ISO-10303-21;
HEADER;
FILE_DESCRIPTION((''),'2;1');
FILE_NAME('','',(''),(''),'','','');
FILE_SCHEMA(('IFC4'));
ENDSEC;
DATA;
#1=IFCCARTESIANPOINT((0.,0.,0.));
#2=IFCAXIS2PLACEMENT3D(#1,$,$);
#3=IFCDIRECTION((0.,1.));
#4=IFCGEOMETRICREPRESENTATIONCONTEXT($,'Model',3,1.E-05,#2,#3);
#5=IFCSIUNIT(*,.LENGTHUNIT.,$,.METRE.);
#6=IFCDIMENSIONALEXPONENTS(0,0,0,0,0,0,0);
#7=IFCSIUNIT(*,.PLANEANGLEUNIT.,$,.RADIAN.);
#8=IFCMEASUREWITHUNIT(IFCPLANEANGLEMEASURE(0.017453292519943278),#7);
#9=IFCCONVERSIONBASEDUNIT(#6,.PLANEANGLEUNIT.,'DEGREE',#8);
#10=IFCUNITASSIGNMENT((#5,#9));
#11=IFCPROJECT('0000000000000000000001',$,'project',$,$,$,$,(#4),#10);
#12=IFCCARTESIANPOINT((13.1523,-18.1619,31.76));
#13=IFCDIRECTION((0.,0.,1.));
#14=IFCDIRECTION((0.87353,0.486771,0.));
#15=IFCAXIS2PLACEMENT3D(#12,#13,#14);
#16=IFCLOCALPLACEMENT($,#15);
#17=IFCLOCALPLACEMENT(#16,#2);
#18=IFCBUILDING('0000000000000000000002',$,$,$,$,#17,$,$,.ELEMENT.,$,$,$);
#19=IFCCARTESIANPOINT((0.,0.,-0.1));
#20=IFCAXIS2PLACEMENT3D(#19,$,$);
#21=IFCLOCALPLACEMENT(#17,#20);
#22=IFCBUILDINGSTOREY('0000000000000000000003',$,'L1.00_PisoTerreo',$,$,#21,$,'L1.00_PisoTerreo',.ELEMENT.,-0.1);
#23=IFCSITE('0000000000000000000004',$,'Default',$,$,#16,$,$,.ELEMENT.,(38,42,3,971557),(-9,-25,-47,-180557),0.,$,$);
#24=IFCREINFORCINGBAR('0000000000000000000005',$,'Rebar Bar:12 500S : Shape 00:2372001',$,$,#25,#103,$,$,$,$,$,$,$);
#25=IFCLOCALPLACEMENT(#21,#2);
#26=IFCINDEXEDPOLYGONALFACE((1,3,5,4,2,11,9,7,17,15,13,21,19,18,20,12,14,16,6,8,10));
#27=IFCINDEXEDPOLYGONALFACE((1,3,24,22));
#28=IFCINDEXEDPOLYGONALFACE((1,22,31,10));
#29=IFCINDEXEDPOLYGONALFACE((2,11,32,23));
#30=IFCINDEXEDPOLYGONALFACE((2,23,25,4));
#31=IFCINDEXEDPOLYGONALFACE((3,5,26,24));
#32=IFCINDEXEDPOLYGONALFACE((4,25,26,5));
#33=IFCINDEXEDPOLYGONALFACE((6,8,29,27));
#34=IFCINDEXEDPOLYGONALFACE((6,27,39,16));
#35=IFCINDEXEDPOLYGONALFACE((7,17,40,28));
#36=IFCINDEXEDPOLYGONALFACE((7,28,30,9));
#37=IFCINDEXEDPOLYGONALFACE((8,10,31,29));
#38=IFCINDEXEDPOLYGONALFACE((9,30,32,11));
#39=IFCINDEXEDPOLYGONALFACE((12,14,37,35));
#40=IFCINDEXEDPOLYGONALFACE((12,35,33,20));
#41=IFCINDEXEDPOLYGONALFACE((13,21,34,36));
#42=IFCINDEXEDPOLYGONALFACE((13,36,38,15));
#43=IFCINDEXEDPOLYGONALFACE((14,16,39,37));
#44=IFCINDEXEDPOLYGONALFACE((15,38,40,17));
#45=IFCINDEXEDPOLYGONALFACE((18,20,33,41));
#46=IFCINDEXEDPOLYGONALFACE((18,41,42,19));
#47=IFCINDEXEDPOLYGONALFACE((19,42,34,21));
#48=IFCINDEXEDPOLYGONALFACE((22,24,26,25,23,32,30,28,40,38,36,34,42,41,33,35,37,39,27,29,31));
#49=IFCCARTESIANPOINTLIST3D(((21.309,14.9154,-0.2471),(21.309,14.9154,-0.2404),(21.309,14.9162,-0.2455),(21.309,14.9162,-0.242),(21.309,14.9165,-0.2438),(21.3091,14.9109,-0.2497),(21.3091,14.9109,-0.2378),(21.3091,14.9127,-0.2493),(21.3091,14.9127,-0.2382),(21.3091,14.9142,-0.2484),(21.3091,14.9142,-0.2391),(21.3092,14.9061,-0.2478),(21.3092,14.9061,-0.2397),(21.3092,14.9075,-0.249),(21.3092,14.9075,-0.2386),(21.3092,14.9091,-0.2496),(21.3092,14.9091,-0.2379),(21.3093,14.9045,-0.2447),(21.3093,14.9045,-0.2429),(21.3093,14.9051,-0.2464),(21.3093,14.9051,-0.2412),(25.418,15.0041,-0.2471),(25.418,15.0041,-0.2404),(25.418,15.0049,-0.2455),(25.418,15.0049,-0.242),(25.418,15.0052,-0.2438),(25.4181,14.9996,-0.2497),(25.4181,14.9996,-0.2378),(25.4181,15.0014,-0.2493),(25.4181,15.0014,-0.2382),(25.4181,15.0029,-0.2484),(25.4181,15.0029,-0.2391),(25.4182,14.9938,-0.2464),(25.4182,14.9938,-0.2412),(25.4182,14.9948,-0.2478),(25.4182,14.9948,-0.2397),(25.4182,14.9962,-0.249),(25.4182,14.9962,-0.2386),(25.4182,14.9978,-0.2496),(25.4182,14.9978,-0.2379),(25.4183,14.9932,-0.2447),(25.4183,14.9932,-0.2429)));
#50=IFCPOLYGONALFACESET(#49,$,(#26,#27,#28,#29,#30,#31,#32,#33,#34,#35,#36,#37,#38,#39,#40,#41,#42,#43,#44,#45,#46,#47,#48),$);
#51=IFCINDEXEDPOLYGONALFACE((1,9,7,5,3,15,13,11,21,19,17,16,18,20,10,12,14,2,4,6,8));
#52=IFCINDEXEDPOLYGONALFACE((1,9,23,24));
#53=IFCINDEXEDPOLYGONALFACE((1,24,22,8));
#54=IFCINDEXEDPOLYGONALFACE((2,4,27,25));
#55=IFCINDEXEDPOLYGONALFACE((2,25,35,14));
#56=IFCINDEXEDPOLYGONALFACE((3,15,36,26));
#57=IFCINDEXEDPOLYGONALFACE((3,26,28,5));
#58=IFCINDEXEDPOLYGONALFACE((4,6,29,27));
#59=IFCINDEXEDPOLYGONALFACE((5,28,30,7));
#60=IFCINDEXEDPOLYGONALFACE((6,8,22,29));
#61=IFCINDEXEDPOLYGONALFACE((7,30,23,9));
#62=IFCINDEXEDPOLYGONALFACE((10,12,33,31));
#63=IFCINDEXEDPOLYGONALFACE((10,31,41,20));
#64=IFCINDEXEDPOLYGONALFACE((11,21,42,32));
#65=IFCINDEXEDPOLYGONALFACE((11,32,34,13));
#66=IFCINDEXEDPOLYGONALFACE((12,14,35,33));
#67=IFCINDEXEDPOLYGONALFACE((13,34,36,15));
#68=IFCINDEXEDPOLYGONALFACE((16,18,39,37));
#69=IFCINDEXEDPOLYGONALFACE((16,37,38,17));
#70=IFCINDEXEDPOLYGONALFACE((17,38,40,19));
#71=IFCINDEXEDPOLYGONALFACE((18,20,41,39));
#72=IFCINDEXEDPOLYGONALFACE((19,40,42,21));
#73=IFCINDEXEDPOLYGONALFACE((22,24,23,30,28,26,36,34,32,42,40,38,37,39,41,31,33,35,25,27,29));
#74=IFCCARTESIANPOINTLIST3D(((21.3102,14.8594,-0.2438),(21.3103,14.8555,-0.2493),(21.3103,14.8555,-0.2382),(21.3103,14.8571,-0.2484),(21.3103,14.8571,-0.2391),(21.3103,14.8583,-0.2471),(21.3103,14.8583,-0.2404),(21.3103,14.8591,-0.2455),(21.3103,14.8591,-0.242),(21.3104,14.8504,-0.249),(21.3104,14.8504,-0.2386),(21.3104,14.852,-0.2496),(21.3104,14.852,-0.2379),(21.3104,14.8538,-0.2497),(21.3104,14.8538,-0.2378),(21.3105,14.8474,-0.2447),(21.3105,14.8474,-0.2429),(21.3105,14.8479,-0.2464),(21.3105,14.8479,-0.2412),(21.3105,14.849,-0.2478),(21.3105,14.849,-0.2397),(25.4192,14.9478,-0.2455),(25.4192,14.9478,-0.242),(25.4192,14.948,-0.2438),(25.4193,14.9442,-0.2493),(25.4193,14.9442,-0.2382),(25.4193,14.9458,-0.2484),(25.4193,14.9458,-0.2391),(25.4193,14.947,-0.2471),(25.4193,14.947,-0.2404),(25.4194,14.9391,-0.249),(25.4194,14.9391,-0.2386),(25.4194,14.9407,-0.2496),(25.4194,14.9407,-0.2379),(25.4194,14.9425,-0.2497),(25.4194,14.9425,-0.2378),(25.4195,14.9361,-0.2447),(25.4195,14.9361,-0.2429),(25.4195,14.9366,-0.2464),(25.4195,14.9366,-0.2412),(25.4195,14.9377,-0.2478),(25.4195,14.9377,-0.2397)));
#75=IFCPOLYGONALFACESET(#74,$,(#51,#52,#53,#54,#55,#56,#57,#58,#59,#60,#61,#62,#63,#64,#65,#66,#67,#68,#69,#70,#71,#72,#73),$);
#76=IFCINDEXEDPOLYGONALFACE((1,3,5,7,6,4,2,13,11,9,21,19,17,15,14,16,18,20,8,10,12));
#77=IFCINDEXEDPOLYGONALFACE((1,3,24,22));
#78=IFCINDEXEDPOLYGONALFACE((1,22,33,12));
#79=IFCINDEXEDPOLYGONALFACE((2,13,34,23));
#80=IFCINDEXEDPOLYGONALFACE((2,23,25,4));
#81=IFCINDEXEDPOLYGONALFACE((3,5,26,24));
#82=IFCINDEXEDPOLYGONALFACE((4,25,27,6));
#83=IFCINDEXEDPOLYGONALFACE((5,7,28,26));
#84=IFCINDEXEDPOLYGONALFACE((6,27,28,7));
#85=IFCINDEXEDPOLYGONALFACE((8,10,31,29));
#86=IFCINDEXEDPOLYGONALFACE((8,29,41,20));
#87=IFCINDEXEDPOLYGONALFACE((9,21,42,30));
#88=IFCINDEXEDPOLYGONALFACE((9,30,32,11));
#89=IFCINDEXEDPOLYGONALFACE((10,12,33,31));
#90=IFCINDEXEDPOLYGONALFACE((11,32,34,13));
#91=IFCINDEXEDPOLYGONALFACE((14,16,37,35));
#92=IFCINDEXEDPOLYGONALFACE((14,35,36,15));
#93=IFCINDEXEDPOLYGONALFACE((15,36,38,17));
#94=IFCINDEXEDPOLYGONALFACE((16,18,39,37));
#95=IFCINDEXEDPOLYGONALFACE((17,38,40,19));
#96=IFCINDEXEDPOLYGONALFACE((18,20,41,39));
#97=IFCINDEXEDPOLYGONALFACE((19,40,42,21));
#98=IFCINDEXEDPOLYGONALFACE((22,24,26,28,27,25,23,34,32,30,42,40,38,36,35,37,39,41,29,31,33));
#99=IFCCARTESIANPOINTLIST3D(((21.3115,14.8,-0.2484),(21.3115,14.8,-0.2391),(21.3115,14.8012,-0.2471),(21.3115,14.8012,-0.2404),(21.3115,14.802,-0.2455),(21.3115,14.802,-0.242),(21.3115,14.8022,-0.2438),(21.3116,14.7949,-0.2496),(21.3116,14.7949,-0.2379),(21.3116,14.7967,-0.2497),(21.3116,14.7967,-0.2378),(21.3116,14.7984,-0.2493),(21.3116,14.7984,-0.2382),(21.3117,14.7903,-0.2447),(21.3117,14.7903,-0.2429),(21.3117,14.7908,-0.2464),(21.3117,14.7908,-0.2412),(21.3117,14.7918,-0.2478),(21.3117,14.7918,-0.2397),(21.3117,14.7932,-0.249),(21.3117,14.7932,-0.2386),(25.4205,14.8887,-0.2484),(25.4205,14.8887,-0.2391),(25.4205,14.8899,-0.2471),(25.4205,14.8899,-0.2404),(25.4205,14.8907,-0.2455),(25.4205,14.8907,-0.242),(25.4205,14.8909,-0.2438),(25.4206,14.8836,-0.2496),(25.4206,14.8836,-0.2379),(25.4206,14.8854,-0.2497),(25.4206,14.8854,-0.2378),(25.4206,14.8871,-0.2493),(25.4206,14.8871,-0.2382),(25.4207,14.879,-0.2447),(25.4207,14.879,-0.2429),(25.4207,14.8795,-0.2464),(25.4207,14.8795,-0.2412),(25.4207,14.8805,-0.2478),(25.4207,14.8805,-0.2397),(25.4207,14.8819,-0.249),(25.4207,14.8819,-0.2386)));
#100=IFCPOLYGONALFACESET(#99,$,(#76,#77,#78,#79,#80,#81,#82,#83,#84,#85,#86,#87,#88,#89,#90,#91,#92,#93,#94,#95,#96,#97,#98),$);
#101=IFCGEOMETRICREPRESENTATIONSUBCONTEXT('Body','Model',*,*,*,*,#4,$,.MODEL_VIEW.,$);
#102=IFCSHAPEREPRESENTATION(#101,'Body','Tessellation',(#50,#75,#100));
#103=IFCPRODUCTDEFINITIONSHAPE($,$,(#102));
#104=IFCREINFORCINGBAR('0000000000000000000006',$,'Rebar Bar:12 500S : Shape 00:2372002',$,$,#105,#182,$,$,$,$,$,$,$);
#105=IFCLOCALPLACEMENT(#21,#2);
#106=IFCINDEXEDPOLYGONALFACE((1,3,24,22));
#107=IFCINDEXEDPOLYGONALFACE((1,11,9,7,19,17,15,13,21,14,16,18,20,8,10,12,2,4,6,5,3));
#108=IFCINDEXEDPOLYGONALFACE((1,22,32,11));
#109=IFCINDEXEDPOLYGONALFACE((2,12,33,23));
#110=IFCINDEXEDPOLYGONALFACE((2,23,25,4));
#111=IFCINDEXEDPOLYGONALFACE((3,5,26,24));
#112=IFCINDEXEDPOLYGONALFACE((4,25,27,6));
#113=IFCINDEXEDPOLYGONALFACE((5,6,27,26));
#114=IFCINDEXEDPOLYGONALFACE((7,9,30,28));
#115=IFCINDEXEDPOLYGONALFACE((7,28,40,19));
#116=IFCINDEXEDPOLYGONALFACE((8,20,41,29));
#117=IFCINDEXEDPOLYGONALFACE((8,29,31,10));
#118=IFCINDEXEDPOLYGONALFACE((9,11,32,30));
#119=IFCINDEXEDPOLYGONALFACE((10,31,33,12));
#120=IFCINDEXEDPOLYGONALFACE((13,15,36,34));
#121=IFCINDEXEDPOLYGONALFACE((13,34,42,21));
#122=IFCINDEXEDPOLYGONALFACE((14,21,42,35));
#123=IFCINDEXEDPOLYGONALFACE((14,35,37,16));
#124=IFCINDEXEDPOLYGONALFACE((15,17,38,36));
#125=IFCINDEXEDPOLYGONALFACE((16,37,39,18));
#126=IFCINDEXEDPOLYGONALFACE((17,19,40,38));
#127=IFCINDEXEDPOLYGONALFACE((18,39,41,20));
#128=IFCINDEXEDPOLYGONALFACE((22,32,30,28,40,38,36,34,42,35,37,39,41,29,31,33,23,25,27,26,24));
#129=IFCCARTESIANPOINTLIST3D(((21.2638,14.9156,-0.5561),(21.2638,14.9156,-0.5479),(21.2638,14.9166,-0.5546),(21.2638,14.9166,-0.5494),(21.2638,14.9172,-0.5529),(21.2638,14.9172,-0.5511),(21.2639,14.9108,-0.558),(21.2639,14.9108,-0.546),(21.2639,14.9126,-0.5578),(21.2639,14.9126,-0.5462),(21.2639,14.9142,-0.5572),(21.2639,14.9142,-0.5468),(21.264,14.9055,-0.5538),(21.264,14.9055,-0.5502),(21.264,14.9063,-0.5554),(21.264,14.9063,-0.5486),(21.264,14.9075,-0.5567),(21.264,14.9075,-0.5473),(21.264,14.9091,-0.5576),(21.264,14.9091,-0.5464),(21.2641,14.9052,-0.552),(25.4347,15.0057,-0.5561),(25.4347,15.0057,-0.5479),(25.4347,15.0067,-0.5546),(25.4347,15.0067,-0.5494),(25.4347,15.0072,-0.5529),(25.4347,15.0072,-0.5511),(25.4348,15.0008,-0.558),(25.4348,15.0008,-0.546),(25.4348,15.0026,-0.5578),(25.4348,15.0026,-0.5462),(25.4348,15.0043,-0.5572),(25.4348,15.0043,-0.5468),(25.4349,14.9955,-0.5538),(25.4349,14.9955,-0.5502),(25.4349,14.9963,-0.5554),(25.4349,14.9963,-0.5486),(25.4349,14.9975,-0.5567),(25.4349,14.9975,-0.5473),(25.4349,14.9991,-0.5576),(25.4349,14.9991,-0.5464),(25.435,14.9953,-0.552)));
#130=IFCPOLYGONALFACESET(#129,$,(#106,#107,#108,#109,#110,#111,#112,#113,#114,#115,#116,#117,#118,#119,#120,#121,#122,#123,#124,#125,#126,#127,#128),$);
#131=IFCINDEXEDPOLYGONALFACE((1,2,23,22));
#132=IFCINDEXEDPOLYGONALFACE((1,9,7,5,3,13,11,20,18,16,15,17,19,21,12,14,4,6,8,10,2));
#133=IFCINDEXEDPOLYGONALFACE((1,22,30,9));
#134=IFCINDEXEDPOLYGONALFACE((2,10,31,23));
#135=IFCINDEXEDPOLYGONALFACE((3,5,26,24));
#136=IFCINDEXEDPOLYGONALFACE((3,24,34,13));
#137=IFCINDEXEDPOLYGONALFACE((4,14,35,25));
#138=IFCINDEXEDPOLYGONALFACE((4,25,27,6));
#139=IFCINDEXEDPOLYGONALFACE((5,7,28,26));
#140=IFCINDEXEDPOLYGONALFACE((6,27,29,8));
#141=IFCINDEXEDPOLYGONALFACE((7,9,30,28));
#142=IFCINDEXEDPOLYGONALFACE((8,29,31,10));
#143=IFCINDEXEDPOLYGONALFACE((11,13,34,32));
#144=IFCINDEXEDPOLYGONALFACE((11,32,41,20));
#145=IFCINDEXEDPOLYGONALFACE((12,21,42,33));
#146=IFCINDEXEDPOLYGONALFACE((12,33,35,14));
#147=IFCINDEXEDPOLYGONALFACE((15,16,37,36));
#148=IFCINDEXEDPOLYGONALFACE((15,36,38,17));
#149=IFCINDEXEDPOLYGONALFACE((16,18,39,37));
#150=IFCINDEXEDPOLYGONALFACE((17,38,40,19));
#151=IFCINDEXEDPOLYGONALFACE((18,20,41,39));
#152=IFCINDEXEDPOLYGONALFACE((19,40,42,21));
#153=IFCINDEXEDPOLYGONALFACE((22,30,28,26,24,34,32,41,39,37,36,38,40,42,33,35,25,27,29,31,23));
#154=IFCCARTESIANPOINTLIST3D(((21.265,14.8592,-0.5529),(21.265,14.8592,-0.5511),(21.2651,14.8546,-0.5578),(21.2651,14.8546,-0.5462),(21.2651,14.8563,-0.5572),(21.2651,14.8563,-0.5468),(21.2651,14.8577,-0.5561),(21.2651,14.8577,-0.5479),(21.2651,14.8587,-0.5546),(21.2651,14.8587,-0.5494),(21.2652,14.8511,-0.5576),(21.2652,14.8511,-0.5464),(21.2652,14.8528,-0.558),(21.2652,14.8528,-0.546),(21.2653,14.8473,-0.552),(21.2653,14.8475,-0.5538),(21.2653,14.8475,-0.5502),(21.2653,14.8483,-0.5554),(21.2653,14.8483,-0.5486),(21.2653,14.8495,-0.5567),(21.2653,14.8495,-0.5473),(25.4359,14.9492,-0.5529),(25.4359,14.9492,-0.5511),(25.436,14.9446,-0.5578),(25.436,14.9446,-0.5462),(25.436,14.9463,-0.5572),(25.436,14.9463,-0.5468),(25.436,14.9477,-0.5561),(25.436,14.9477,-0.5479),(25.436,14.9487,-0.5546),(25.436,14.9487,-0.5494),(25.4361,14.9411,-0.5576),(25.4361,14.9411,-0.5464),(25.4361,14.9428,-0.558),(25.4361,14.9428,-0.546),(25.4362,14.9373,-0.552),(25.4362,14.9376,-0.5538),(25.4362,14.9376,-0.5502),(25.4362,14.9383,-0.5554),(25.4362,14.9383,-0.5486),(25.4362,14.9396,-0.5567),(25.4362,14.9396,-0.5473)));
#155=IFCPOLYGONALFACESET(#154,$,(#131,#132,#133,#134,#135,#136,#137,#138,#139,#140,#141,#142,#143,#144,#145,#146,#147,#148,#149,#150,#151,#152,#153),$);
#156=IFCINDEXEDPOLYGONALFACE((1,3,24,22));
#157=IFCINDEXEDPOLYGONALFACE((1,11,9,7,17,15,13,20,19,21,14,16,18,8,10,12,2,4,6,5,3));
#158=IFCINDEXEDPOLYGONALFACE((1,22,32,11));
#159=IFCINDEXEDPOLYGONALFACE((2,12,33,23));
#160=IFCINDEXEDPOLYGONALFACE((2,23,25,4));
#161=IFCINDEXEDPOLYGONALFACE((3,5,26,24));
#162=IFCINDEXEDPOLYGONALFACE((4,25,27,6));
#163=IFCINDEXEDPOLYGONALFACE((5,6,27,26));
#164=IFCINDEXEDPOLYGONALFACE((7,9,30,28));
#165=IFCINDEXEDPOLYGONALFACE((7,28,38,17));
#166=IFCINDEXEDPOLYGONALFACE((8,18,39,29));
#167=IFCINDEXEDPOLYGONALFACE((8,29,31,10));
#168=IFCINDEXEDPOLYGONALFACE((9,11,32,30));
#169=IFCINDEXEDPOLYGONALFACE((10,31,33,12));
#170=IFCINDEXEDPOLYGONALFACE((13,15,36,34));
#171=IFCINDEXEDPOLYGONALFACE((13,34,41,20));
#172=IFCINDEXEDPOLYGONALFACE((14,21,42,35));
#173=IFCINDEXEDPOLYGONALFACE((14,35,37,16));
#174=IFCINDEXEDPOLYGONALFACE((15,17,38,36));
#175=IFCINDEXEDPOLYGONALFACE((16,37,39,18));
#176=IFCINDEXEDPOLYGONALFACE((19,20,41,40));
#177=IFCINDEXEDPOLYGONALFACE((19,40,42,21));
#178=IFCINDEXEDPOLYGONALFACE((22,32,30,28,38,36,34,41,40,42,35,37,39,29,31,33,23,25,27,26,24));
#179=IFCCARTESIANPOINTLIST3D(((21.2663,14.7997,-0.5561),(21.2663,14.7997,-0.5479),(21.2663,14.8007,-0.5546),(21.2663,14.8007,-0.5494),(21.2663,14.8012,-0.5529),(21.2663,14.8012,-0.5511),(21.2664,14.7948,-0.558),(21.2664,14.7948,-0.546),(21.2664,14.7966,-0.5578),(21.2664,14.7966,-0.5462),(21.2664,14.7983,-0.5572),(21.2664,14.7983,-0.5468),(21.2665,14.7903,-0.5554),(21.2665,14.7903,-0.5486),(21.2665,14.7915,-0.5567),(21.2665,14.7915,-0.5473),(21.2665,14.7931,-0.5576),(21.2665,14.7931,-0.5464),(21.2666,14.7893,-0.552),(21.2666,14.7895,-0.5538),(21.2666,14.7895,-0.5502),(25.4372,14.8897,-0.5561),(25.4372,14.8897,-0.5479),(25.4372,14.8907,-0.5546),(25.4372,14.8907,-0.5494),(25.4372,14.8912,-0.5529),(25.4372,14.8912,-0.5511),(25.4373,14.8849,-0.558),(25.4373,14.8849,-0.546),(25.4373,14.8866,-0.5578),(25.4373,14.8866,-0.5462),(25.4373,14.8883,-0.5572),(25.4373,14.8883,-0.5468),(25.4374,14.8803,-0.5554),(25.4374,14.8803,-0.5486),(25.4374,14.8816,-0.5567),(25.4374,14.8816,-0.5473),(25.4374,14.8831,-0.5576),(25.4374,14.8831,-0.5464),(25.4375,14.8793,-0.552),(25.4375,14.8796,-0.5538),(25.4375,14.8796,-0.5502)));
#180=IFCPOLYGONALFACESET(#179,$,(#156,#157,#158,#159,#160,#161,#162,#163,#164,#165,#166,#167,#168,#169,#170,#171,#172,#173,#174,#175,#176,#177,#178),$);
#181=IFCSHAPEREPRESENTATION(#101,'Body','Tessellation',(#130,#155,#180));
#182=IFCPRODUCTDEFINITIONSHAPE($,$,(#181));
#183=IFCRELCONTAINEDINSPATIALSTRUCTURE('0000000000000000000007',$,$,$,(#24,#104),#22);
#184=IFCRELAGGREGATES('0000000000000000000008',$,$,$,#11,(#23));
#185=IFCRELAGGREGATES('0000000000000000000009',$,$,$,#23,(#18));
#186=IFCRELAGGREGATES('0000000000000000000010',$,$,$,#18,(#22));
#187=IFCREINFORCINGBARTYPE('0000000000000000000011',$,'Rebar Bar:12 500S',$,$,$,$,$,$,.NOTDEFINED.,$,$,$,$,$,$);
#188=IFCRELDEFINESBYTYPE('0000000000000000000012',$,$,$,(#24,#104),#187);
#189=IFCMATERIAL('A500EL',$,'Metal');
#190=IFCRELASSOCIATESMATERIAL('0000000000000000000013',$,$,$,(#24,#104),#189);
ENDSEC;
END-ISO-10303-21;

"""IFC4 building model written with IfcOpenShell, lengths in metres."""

from ifc_helpers import new_model, entity, si_unit, converted_unit, direction, frame, origin, place, context, subcontext, project, spatial, material, type_object, element, save


model = new_model("IFC4")

# Units and contexts
model_context = context("Model", 3, precision=1e-05, world=origin(), true_north=direction((0.0, 1.0)))
body_context = subcontext(model_context, "Body", "Model", "MODEL_VIEW")
ifc_project = project(units=[si_unit("LENGTHUNIT", "METRE"), converted_unit("PLANEANGLEUNIT", "DEGREE", entity("IfcPlaneAngleMeasure", 0.017453292519943278), si_unit("PLANEANGLEUNIT", "RADIAN"), dimensions=[0, 0, 0, 0, 0, 0, 0])], contexts=[model_context])

# Site, building, storey
site_placement = place(None, frame((13.1523, -18.1619, 31.76), z_axis=(0.0, 0.0, 1.0), x_axis=(0.87353, 0.486771, 0.0)))
site = spatial("IfcSite", under=ifc_project, at=site_placement, Name="Default", CompositionType="ELEMENT", RefLatitude=(38, 42, 3, 971557), RefLongitude=(-9, -25, -47, -180557), RefElevation=0.0)
building_placement = place(site_placement, origin())
building = spatial("IfcBuilding", under=site, at=building_placement, CompositionType="ELEMENT")
storey_placement = place(building_placement, frame((0.0, 0.0, -0.1)))
storey = spatial("IfcBuildingStorey", under=building, at=storey_placement, Name="L1.00_PisoTerreo", LongName="L1.00_PisoTerreo", CompositionType="ELEMENT", Elevation=-0.1)

# Reinforcing bars
ifc_material = material(Name="A500EL", Category="Metal")
reinforcing_bar_type_1 = type_object("IfcReinforcingBarType", Name="Rebar Bar:12 500S", PredefinedType="NOTDEFINED")
reinforcing_bar_1_placement = place(storey_placement, origin())
element("IfcReinforcingBar", 1, at=reinforcing_bar_1_placement, inside=storey, type_object=reinforcing_bar_type_1, material=ifc_material, Name="Rebar Bar:12 500S : Shape 00:2372001", context=body_context, shape_type="AdvancedSweptSolid", body=[
    entity("IfcSweptDiskSolid", entity("IfcIndexedPolyCurve", entity("IfcCartesianPointList3D", [[21.3091, 14.9105, -0.2438], [25.4181, 14.9992, -0.2438]]), None, False), 0.006, None, 0.0, 1.0),
    entity("IfcSweptDiskSolid", entity("IfcIndexedPolyCurve", entity("IfcCartesianPointList3D", [[21.3104, 14.8534, -0.2438], [25.4194, 14.9421, -0.2438]]), None, False), 0.006, None, 0.0, 1.0),
    entity("IfcSweptDiskSolid", entity("IfcIndexedPolyCurve", entity("IfcCartesianPointList3D", [[21.3116, 14.7962, -0.2438], [25.4206, 14.8849, -0.2438]]), None, False), 0.006, None, 0.0, 1.0),
])
reinforcing_bar_2_placement = place(storey_placement, origin())
element("IfcReinforcingBar", 2, at=reinforcing_bar_2_placement, inside=storey, type_object=reinforcing_bar_type_1, material=ifc_material, Name="Rebar Bar:12 500S : Shape 00:2372002", context=body_context, shape_type="AdvancedSweptSolid", body=[
    entity("IfcSweptDiskSolid", entity("IfcIndexedPolyCurve", entity("IfcCartesianPointList3D", [[25.4348, 15.0013, -0.552], [21.2639, 14.9112, -0.552]]), None, False), 0.006, None, 0.0, 1.0),
    entity("IfcSweptDiskSolid", entity("IfcIndexedPolyCurve", entity("IfcCartesianPointList3D", [[25.4361, 14.9433, -0.552], [21.2652, 14.8533, -0.552]]), None, False), 0.006, None, 0.0, 1.0),
    entity("IfcSweptDiskSolid", entity("IfcIndexedPolyCurve", entity("IfcCartesianPointList3D", [[25.4373, 14.8853, -0.552], [21.2664, 14.7953, -0.552]]), None, False), 0.006, None, 0.0, 1.0),
])

save(model, "model.ifc")
